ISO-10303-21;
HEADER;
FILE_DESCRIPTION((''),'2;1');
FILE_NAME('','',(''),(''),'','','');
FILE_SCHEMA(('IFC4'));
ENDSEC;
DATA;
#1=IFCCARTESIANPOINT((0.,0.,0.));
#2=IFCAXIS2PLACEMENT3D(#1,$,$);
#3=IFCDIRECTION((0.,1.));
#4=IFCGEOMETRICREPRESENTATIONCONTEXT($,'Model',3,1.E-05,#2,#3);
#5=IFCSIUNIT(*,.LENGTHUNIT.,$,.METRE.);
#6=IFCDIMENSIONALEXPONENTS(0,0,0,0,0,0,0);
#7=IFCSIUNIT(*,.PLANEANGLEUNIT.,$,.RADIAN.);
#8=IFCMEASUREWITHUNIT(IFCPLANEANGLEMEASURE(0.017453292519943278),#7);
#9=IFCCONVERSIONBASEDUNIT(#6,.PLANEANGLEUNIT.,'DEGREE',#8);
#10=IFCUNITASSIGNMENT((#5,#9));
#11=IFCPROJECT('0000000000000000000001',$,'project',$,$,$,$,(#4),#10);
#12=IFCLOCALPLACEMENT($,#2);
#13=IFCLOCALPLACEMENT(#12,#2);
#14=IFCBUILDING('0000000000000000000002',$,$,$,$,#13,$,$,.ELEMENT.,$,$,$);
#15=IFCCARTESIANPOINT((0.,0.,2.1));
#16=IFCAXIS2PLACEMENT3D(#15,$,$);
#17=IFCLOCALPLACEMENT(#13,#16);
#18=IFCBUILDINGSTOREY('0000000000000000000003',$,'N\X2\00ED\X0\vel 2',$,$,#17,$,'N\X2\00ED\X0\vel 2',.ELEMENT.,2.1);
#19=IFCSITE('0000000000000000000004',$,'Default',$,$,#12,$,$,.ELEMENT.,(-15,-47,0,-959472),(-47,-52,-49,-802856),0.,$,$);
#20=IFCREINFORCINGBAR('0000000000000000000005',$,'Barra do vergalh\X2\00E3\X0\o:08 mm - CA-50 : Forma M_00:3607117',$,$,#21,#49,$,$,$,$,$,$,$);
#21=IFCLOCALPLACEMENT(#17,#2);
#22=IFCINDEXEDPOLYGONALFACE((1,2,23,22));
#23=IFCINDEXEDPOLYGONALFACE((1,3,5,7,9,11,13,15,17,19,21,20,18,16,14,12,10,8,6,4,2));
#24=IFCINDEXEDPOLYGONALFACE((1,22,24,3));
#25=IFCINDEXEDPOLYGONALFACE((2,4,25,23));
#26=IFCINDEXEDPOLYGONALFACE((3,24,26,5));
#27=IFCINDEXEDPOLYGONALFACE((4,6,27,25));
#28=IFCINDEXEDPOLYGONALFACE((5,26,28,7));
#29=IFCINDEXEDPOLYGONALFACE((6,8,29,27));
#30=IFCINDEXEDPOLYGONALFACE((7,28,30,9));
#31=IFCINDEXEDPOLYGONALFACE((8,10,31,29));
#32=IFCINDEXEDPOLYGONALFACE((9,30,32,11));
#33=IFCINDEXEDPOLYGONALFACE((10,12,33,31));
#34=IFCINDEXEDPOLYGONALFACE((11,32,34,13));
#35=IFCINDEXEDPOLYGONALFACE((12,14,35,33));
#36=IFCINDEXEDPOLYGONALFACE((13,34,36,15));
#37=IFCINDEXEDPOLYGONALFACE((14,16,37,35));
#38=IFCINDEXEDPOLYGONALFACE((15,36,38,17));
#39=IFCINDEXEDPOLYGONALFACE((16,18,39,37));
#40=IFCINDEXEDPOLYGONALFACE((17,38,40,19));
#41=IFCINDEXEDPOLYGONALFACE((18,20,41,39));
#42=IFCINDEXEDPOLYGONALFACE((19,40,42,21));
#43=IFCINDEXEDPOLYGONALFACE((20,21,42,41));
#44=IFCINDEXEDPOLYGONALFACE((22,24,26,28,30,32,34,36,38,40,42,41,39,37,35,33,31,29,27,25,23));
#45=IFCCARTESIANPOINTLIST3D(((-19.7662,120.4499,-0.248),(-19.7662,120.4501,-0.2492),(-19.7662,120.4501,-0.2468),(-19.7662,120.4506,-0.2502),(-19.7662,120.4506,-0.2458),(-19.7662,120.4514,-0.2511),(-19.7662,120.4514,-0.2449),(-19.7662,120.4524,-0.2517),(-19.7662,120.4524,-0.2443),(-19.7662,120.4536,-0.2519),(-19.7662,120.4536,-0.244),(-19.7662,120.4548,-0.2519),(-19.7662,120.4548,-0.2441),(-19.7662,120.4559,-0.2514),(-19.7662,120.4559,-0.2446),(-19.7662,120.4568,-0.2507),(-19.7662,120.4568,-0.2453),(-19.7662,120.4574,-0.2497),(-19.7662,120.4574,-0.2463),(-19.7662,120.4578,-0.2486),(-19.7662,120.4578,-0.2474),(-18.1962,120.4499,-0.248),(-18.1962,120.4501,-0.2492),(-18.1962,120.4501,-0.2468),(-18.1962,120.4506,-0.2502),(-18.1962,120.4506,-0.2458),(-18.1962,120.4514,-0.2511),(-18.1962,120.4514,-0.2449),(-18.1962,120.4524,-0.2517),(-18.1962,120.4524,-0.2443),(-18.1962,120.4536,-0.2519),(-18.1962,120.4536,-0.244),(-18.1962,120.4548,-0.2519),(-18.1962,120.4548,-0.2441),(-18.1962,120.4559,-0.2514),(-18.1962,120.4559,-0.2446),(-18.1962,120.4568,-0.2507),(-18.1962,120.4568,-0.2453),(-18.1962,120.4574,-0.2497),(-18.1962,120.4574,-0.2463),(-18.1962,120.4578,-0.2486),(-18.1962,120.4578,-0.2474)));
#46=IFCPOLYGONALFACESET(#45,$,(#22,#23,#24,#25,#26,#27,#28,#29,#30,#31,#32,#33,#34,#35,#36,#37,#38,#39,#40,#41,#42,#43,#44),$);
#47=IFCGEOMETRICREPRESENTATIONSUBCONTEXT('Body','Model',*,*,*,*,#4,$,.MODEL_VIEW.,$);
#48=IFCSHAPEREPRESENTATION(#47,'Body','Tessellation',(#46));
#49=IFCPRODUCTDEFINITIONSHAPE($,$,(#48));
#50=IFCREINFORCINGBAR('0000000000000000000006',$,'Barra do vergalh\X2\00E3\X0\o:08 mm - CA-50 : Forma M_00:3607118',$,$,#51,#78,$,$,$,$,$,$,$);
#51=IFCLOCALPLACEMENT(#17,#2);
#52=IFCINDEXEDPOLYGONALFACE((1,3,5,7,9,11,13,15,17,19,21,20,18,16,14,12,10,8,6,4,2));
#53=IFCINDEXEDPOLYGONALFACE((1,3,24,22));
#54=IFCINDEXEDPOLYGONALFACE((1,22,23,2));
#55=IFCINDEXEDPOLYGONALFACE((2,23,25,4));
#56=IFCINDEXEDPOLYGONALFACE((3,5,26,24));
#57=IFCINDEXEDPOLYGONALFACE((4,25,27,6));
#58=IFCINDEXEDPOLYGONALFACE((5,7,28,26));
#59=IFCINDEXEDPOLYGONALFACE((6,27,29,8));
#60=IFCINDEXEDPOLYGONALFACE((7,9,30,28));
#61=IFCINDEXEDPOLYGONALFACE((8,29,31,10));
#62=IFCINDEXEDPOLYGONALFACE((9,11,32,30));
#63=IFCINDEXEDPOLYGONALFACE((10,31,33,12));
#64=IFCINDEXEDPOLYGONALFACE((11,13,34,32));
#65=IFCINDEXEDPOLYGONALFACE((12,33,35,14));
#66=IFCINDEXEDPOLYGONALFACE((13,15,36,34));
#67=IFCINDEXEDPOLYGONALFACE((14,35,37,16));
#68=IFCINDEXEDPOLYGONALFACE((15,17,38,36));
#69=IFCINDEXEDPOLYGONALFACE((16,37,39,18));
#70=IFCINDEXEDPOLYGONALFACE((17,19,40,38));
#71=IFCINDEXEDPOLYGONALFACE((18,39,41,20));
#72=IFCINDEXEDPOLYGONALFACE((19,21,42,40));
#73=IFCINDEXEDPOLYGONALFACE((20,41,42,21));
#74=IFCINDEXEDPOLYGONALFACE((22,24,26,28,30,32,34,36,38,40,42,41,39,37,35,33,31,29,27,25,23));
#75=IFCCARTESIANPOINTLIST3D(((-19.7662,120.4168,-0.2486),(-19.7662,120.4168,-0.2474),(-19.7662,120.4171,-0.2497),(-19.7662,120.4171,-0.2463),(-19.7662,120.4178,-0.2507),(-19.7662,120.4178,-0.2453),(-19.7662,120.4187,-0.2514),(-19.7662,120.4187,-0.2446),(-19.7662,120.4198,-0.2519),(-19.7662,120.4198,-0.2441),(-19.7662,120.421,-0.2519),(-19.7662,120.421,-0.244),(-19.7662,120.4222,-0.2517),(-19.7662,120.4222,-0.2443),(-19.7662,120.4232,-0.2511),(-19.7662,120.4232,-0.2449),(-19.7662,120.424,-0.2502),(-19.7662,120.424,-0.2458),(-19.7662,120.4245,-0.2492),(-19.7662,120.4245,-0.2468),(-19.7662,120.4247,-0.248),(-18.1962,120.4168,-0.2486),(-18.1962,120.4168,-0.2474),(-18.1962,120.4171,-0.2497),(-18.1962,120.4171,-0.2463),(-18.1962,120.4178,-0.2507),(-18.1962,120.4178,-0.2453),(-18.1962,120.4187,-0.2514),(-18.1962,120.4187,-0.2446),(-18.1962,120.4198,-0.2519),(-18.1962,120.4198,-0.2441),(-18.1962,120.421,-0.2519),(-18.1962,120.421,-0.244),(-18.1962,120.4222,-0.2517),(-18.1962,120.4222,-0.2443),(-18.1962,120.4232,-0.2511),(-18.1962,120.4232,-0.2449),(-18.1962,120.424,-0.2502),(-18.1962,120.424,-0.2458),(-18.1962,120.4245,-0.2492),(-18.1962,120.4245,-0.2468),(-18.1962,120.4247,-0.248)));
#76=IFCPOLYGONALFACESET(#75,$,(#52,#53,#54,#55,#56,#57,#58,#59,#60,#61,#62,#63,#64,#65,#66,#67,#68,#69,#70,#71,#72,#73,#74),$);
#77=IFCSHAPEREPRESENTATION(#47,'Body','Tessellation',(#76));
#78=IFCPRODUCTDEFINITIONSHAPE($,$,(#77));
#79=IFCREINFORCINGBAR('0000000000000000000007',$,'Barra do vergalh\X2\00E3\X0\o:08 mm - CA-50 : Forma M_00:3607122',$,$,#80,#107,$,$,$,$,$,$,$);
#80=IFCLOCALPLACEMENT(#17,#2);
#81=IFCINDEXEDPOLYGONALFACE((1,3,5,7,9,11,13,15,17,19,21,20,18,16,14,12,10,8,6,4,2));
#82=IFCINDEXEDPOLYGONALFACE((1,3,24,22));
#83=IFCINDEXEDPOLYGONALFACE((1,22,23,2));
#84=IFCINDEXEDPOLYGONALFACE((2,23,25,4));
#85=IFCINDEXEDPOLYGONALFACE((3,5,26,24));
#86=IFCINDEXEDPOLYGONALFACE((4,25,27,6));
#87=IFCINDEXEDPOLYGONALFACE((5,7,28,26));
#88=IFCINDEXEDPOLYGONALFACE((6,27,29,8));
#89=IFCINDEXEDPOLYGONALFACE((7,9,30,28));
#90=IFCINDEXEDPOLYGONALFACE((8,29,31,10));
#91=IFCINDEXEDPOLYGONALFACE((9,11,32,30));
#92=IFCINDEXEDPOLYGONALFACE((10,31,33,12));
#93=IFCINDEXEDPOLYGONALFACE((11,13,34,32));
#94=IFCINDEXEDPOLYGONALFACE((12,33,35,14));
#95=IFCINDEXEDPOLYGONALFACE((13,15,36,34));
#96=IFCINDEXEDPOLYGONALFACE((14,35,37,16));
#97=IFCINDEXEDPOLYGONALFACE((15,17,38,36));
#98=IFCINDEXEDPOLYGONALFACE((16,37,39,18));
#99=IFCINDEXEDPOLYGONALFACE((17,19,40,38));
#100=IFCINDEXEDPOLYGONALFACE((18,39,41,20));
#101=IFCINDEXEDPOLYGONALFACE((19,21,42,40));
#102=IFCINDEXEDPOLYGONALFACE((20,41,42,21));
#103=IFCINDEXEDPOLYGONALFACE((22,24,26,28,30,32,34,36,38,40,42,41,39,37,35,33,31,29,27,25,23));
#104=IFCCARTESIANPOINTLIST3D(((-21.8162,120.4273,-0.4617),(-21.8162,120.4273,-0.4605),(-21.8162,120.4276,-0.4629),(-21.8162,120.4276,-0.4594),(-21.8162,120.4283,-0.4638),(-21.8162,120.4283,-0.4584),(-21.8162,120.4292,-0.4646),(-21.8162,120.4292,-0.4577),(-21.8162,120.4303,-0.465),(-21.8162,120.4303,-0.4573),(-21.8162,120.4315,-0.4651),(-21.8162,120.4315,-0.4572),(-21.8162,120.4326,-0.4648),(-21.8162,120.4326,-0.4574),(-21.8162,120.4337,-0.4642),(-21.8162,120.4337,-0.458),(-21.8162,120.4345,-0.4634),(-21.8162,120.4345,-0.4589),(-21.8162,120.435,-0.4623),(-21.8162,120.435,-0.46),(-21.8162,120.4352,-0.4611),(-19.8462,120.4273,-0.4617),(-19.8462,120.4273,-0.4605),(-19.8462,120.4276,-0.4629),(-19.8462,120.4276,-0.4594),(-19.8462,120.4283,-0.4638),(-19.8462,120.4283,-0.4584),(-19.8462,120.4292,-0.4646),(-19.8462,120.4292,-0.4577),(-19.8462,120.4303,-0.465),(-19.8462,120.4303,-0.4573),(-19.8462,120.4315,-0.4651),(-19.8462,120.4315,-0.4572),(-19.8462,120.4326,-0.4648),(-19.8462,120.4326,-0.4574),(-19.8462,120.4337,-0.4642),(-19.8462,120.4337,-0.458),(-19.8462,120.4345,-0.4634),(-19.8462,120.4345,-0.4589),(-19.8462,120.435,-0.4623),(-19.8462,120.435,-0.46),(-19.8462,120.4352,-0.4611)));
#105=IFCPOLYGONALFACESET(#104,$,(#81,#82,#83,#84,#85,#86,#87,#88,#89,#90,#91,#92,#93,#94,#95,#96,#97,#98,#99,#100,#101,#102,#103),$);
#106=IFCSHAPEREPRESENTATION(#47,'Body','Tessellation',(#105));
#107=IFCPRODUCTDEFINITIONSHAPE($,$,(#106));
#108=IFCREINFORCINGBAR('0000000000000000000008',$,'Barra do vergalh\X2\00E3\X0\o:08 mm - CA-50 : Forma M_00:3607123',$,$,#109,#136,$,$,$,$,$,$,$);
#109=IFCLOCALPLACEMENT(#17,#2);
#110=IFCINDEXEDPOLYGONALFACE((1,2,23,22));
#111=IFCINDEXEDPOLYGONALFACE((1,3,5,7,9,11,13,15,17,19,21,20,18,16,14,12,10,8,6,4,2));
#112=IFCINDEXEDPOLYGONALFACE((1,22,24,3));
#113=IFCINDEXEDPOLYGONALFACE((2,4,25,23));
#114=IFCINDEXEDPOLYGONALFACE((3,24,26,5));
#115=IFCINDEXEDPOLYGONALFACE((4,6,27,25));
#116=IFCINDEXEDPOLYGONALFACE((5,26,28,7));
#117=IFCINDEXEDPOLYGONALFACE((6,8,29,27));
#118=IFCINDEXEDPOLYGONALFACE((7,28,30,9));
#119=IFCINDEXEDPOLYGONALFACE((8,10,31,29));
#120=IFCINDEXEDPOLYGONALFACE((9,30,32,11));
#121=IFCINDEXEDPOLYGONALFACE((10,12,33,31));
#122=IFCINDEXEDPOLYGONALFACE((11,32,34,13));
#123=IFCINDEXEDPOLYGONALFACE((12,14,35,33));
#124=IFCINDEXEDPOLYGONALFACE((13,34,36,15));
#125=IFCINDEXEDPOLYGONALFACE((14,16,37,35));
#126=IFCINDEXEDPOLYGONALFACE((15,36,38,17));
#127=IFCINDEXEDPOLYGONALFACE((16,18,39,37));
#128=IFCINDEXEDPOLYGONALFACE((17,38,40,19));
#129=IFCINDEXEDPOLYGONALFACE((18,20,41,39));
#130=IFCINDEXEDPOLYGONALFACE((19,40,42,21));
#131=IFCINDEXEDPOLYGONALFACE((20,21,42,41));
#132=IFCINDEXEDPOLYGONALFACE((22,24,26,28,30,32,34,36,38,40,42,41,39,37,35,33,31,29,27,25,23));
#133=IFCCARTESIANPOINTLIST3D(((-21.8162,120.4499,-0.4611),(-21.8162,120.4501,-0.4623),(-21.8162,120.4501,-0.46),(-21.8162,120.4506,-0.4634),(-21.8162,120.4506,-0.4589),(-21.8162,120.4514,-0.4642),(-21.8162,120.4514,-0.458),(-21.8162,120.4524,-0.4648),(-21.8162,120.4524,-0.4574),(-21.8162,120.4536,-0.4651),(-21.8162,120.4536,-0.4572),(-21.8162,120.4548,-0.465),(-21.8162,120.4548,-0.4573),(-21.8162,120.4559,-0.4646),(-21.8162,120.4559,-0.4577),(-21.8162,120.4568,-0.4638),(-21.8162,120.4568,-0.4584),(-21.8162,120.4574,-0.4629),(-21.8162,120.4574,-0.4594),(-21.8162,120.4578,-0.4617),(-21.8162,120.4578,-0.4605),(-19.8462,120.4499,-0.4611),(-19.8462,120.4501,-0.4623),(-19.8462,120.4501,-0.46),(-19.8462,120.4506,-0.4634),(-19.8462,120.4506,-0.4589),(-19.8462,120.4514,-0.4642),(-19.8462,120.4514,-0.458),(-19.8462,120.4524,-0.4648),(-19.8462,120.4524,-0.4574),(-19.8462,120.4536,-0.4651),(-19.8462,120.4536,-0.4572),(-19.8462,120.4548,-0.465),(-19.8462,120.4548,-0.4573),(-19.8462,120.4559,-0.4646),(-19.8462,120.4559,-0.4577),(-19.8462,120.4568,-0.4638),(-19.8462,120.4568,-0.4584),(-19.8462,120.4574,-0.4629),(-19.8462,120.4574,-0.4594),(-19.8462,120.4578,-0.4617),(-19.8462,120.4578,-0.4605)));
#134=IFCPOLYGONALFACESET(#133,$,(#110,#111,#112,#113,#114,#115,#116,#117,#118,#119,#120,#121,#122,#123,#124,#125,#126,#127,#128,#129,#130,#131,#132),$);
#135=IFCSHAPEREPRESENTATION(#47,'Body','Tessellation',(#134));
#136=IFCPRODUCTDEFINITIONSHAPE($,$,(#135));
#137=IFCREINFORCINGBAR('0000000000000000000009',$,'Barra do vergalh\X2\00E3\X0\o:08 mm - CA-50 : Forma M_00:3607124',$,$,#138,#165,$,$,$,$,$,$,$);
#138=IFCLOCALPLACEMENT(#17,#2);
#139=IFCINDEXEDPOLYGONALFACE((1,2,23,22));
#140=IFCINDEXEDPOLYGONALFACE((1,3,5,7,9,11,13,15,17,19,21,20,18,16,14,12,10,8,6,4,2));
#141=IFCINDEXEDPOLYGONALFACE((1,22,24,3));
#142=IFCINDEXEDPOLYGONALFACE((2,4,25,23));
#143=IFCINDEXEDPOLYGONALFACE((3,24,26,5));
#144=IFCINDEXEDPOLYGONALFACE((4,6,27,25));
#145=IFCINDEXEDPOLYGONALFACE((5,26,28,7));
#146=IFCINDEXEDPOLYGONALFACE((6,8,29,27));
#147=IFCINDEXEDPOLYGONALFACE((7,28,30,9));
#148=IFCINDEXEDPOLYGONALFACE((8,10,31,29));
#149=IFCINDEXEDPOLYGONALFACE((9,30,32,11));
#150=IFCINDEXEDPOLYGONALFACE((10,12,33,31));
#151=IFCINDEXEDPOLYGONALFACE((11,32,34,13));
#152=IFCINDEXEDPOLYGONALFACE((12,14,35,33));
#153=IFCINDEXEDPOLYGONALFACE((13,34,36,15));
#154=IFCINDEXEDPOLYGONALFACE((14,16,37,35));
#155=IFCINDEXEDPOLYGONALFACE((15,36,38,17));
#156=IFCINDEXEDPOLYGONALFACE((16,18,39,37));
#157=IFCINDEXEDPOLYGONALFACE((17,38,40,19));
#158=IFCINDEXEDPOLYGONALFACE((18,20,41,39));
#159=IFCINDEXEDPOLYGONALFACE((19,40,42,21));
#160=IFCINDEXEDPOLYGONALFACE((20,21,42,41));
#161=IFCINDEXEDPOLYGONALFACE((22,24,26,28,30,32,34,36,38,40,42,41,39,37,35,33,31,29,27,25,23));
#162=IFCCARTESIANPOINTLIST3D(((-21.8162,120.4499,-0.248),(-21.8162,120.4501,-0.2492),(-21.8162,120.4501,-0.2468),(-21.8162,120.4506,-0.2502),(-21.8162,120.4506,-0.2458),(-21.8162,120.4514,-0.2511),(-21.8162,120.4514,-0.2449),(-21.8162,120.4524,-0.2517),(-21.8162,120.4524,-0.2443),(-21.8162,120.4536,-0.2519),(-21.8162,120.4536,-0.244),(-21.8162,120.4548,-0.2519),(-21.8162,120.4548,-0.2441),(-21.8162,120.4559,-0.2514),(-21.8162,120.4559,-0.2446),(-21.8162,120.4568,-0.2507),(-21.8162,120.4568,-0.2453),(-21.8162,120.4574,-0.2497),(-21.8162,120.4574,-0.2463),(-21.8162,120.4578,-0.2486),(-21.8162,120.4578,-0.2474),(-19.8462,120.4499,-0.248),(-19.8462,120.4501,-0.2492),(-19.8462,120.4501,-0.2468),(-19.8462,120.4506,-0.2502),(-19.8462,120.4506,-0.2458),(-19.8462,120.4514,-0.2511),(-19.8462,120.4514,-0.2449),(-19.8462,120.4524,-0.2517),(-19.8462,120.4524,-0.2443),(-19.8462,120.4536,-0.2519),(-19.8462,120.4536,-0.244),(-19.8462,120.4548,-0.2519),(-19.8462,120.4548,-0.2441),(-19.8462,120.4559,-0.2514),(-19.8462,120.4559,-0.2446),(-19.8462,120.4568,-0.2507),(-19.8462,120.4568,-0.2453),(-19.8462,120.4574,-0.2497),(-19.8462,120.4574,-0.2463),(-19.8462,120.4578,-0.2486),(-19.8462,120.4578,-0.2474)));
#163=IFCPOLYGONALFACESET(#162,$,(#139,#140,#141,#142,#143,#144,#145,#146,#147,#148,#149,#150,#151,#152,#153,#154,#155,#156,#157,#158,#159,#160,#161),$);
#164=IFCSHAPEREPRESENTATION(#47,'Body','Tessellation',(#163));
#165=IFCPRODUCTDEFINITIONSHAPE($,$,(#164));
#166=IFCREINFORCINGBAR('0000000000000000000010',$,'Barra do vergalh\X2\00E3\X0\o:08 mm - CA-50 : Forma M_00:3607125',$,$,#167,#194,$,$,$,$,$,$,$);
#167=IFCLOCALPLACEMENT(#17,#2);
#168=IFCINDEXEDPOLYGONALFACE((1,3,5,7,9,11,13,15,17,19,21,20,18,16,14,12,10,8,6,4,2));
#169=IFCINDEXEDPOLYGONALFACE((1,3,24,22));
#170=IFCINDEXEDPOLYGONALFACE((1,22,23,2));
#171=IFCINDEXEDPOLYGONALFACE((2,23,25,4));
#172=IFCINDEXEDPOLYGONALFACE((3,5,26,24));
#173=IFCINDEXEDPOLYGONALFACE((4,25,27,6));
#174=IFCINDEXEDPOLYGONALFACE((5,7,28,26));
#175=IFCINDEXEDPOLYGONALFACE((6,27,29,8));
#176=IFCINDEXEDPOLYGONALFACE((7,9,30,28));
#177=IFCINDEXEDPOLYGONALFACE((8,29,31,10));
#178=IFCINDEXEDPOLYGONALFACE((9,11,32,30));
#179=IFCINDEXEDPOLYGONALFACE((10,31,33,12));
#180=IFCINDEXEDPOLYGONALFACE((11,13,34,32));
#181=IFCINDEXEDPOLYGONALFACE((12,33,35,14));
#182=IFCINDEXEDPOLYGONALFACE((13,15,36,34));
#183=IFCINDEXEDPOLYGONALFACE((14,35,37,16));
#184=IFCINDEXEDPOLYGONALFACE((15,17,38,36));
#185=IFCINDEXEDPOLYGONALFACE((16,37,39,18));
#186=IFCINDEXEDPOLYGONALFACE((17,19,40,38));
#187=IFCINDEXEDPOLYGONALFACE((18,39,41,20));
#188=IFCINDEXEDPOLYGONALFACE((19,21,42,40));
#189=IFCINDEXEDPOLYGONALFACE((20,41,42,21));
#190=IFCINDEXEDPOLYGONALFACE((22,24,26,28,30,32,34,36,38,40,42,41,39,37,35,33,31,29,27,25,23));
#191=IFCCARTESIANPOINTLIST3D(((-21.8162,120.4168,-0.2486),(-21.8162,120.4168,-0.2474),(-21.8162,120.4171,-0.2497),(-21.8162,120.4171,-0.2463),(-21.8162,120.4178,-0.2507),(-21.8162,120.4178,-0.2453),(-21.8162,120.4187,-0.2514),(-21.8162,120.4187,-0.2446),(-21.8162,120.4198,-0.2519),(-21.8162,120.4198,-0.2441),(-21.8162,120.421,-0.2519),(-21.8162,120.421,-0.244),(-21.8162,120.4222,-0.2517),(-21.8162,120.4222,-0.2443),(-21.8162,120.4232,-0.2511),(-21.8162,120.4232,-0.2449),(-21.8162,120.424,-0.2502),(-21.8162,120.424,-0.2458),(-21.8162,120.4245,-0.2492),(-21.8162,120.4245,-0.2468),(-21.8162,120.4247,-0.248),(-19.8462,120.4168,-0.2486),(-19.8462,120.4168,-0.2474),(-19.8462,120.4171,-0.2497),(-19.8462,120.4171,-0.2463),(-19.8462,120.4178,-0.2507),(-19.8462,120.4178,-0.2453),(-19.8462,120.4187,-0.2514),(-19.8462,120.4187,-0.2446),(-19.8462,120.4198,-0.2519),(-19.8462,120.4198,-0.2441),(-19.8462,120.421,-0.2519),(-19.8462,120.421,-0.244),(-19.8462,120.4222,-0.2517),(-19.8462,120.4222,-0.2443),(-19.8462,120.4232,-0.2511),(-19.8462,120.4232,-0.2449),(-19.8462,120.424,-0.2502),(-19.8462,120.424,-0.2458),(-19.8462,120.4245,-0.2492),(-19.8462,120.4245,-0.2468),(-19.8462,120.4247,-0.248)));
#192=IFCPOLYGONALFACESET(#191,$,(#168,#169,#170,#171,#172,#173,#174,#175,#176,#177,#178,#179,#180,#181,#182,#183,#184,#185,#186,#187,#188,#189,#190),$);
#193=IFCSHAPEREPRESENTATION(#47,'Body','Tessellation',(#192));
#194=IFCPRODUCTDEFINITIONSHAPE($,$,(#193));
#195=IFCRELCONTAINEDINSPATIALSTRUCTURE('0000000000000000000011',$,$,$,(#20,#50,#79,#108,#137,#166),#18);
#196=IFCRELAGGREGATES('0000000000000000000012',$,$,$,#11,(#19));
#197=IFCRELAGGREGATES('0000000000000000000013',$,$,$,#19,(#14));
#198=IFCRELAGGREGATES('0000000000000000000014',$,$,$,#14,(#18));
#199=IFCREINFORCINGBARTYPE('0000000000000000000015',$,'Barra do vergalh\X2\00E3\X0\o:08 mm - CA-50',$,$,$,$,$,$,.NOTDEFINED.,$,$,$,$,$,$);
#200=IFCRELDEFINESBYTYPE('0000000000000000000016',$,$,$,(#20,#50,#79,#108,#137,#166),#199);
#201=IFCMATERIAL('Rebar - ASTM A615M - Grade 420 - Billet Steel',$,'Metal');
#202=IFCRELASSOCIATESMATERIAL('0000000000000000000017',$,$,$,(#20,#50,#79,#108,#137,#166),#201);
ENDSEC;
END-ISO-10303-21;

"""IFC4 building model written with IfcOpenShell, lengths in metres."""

from ifc_helpers import new_model, entity, si_unit, converted_unit, direction, frame, origin, place, context, subcontext, project, spatial, material, type_object, element, save


model = new_model("IFC4")

# Units and contexts
model_context = context("Model", 3, precision=1e-05, world=origin(), true_north=direction((0.0, 1.0)))
body_context = subcontext(model_context, "Body", "Model", "MODEL_VIEW")
ifc_project = project(units=[si_unit("LENGTHUNIT", "METRE"), converted_unit("PLANEANGLEUNIT", "DEGREE", entity("IfcPlaneAngleMeasure", 0.017453292519943278), si_unit("PLANEANGLEUNIT", "RADIAN"), dimensions=[0, 0, 0, 0, 0, 0, 0])], contexts=[model_context])

# Site, building, storey
site_placement = place(None, origin())
site = spatial("IfcSite", under=ifc_project, at=site_placement, Name="Default", CompositionType="ELEMENT", RefLatitude=(-15, -47, 0, -959472), RefLongitude=(-47, -52, -49, -802856), RefElevation=0.0)
building_placement = place(site_placement, origin())
building = spatial("IfcBuilding", under=site, at=building_placement, CompositionType="ELEMENT")
storey_placement = place(building_placement, frame((0.0, 0.0, 2.1)))
storey = spatial("IfcBuildingStorey", under=building, at=storey_placement, Name="Nível 2", LongName="Nível 2", CompositionType="ELEMENT", Elevation=2.1)

# Reinforcing bars
ifc_material = material(Name="Rebar - ASTM A615M - Grade 420 - Billet Steel", Category="Metal")
reinforcing_bar_type_1 = type_object("IfcReinforcingBarType", Name="Barra do vergalhão:08 mm - CA-50", PredefinedType="NOTDEFINED")
reinforcing_bar_1_placement = place(storey_placement, origin())
element("IfcReinforcingBar", 1, at=reinforcing_bar_1_placement, inside=storey, type_object=reinforcing_bar_type_1, material=ifc_material, Name="Barra do vergalhão:08 mm - CA-50 : Forma M_00:3607117", context=body_context, shape_type="AdvancedSweptSolid", body=[
    entity("IfcSweptDiskSolid", entity("IfcIndexedPolyCurve", entity("IfcCartesianPointList3D", [[19.7662, -120.4539, 0.248], [18.1962, -120.4539, 0.248]]), None, False), 0.004, None, 0.0, 1.0),
])
reinforcing_bar_2_placement = place(storey_placement, origin())
element("IfcReinforcingBar", 2, at=reinforcing_bar_2_placement, inside=storey, type_object=reinforcing_bar_type_1, material=ifc_material, Name="Barra do vergalhão:08 mm - CA-50 : Forma M_00:3607118", context=body_context, shape_type="AdvancedSweptSolid", body=[
    entity("IfcSweptDiskSolid", entity("IfcIndexedPolyCurve", entity("IfcCartesianPointList3D", [[18.1962, -120.4207, 0.248], [19.7662, -120.4207, 0.248]]), None, False), 0.004, None, 0.0, 1.0),
])
reinforcing_bar_3_placement = place(storey_placement, origin())
element("IfcReinforcingBar", 3, at=reinforcing_bar_3_placement, inside=storey, type_object=reinforcing_bar_type_1, material=ifc_material, Name="Barra do vergalhão:08 mm - CA-50 : Forma M_00:3607122", context=body_context, shape_type="AdvancedSweptSolid", body=[
    entity("IfcSweptDiskSolid", entity("IfcIndexedPolyCurve", entity("IfcCartesianPointList3D", [[19.8462, -120.4312, 0.4611], [21.8162, -120.4312, 0.4611]]), None, False), 0.004, None, 0.0, 1.0),
])
reinforcing_bar_4_placement = place(storey_placement, origin())
element("IfcReinforcingBar", 4, at=reinforcing_bar_4_placement, inside=storey, type_object=reinforcing_bar_type_1, material=ifc_material, Name="Barra do vergalhão:08 mm - CA-50 : Forma M_00:3607123", context=body_context, shape_type="AdvancedSweptSolid", body=[
    entity("IfcSweptDiskSolid", entity("IfcIndexedPolyCurve", entity("IfcCartesianPointList3D", [[21.8162, -120.4539, 0.4611], [19.8462, -120.4539, 0.4611]]), None, False), 0.004, None, 0.0, 1.0),
])
reinforcing_bar_5_placement = place(storey_placement, origin())
element("IfcReinforcingBar", 5, at=reinforcing_bar_5_placement, inside=storey, type_object=reinforcing_bar_type_1, material=ifc_material, Name="Barra do vergalhão:08 mm - CA-50 : Forma M_00:3607124", context=body_context, shape_type="AdvancedSweptSolid", body=[
    entity("IfcSweptDiskSolid", entity("IfcIndexedPolyCurve", entity("IfcCartesianPointList3D", [[21.8162, -120.4539, 0.248], [19.8462, -120.4539, 0.248]]), None, False), 0.004, None, 0.0, 1.0),
])
reinforcing_bar_6_placement = place(storey_placement, origin())
element("IfcReinforcingBar", 6, at=reinforcing_bar_6_placement, inside=storey, type_object=reinforcing_bar_type_1, material=ifc_material, Name="Barra do vergalhão:08 mm - CA-50 : Forma M_00:3607125", context=body_context, shape_type="AdvancedSweptSolid", body=[
    entity("IfcSweptDiskSolid", entity("IfcIndexedPolyCurve", entity("IfcCartesianPointList3D", [[19.8462, -120.4207, 0.248], [21.8162, -120.4207, 0.248]]), None, False), 0.004, None, 0.0, 1.0),
])

save(model, "model.ifc")
